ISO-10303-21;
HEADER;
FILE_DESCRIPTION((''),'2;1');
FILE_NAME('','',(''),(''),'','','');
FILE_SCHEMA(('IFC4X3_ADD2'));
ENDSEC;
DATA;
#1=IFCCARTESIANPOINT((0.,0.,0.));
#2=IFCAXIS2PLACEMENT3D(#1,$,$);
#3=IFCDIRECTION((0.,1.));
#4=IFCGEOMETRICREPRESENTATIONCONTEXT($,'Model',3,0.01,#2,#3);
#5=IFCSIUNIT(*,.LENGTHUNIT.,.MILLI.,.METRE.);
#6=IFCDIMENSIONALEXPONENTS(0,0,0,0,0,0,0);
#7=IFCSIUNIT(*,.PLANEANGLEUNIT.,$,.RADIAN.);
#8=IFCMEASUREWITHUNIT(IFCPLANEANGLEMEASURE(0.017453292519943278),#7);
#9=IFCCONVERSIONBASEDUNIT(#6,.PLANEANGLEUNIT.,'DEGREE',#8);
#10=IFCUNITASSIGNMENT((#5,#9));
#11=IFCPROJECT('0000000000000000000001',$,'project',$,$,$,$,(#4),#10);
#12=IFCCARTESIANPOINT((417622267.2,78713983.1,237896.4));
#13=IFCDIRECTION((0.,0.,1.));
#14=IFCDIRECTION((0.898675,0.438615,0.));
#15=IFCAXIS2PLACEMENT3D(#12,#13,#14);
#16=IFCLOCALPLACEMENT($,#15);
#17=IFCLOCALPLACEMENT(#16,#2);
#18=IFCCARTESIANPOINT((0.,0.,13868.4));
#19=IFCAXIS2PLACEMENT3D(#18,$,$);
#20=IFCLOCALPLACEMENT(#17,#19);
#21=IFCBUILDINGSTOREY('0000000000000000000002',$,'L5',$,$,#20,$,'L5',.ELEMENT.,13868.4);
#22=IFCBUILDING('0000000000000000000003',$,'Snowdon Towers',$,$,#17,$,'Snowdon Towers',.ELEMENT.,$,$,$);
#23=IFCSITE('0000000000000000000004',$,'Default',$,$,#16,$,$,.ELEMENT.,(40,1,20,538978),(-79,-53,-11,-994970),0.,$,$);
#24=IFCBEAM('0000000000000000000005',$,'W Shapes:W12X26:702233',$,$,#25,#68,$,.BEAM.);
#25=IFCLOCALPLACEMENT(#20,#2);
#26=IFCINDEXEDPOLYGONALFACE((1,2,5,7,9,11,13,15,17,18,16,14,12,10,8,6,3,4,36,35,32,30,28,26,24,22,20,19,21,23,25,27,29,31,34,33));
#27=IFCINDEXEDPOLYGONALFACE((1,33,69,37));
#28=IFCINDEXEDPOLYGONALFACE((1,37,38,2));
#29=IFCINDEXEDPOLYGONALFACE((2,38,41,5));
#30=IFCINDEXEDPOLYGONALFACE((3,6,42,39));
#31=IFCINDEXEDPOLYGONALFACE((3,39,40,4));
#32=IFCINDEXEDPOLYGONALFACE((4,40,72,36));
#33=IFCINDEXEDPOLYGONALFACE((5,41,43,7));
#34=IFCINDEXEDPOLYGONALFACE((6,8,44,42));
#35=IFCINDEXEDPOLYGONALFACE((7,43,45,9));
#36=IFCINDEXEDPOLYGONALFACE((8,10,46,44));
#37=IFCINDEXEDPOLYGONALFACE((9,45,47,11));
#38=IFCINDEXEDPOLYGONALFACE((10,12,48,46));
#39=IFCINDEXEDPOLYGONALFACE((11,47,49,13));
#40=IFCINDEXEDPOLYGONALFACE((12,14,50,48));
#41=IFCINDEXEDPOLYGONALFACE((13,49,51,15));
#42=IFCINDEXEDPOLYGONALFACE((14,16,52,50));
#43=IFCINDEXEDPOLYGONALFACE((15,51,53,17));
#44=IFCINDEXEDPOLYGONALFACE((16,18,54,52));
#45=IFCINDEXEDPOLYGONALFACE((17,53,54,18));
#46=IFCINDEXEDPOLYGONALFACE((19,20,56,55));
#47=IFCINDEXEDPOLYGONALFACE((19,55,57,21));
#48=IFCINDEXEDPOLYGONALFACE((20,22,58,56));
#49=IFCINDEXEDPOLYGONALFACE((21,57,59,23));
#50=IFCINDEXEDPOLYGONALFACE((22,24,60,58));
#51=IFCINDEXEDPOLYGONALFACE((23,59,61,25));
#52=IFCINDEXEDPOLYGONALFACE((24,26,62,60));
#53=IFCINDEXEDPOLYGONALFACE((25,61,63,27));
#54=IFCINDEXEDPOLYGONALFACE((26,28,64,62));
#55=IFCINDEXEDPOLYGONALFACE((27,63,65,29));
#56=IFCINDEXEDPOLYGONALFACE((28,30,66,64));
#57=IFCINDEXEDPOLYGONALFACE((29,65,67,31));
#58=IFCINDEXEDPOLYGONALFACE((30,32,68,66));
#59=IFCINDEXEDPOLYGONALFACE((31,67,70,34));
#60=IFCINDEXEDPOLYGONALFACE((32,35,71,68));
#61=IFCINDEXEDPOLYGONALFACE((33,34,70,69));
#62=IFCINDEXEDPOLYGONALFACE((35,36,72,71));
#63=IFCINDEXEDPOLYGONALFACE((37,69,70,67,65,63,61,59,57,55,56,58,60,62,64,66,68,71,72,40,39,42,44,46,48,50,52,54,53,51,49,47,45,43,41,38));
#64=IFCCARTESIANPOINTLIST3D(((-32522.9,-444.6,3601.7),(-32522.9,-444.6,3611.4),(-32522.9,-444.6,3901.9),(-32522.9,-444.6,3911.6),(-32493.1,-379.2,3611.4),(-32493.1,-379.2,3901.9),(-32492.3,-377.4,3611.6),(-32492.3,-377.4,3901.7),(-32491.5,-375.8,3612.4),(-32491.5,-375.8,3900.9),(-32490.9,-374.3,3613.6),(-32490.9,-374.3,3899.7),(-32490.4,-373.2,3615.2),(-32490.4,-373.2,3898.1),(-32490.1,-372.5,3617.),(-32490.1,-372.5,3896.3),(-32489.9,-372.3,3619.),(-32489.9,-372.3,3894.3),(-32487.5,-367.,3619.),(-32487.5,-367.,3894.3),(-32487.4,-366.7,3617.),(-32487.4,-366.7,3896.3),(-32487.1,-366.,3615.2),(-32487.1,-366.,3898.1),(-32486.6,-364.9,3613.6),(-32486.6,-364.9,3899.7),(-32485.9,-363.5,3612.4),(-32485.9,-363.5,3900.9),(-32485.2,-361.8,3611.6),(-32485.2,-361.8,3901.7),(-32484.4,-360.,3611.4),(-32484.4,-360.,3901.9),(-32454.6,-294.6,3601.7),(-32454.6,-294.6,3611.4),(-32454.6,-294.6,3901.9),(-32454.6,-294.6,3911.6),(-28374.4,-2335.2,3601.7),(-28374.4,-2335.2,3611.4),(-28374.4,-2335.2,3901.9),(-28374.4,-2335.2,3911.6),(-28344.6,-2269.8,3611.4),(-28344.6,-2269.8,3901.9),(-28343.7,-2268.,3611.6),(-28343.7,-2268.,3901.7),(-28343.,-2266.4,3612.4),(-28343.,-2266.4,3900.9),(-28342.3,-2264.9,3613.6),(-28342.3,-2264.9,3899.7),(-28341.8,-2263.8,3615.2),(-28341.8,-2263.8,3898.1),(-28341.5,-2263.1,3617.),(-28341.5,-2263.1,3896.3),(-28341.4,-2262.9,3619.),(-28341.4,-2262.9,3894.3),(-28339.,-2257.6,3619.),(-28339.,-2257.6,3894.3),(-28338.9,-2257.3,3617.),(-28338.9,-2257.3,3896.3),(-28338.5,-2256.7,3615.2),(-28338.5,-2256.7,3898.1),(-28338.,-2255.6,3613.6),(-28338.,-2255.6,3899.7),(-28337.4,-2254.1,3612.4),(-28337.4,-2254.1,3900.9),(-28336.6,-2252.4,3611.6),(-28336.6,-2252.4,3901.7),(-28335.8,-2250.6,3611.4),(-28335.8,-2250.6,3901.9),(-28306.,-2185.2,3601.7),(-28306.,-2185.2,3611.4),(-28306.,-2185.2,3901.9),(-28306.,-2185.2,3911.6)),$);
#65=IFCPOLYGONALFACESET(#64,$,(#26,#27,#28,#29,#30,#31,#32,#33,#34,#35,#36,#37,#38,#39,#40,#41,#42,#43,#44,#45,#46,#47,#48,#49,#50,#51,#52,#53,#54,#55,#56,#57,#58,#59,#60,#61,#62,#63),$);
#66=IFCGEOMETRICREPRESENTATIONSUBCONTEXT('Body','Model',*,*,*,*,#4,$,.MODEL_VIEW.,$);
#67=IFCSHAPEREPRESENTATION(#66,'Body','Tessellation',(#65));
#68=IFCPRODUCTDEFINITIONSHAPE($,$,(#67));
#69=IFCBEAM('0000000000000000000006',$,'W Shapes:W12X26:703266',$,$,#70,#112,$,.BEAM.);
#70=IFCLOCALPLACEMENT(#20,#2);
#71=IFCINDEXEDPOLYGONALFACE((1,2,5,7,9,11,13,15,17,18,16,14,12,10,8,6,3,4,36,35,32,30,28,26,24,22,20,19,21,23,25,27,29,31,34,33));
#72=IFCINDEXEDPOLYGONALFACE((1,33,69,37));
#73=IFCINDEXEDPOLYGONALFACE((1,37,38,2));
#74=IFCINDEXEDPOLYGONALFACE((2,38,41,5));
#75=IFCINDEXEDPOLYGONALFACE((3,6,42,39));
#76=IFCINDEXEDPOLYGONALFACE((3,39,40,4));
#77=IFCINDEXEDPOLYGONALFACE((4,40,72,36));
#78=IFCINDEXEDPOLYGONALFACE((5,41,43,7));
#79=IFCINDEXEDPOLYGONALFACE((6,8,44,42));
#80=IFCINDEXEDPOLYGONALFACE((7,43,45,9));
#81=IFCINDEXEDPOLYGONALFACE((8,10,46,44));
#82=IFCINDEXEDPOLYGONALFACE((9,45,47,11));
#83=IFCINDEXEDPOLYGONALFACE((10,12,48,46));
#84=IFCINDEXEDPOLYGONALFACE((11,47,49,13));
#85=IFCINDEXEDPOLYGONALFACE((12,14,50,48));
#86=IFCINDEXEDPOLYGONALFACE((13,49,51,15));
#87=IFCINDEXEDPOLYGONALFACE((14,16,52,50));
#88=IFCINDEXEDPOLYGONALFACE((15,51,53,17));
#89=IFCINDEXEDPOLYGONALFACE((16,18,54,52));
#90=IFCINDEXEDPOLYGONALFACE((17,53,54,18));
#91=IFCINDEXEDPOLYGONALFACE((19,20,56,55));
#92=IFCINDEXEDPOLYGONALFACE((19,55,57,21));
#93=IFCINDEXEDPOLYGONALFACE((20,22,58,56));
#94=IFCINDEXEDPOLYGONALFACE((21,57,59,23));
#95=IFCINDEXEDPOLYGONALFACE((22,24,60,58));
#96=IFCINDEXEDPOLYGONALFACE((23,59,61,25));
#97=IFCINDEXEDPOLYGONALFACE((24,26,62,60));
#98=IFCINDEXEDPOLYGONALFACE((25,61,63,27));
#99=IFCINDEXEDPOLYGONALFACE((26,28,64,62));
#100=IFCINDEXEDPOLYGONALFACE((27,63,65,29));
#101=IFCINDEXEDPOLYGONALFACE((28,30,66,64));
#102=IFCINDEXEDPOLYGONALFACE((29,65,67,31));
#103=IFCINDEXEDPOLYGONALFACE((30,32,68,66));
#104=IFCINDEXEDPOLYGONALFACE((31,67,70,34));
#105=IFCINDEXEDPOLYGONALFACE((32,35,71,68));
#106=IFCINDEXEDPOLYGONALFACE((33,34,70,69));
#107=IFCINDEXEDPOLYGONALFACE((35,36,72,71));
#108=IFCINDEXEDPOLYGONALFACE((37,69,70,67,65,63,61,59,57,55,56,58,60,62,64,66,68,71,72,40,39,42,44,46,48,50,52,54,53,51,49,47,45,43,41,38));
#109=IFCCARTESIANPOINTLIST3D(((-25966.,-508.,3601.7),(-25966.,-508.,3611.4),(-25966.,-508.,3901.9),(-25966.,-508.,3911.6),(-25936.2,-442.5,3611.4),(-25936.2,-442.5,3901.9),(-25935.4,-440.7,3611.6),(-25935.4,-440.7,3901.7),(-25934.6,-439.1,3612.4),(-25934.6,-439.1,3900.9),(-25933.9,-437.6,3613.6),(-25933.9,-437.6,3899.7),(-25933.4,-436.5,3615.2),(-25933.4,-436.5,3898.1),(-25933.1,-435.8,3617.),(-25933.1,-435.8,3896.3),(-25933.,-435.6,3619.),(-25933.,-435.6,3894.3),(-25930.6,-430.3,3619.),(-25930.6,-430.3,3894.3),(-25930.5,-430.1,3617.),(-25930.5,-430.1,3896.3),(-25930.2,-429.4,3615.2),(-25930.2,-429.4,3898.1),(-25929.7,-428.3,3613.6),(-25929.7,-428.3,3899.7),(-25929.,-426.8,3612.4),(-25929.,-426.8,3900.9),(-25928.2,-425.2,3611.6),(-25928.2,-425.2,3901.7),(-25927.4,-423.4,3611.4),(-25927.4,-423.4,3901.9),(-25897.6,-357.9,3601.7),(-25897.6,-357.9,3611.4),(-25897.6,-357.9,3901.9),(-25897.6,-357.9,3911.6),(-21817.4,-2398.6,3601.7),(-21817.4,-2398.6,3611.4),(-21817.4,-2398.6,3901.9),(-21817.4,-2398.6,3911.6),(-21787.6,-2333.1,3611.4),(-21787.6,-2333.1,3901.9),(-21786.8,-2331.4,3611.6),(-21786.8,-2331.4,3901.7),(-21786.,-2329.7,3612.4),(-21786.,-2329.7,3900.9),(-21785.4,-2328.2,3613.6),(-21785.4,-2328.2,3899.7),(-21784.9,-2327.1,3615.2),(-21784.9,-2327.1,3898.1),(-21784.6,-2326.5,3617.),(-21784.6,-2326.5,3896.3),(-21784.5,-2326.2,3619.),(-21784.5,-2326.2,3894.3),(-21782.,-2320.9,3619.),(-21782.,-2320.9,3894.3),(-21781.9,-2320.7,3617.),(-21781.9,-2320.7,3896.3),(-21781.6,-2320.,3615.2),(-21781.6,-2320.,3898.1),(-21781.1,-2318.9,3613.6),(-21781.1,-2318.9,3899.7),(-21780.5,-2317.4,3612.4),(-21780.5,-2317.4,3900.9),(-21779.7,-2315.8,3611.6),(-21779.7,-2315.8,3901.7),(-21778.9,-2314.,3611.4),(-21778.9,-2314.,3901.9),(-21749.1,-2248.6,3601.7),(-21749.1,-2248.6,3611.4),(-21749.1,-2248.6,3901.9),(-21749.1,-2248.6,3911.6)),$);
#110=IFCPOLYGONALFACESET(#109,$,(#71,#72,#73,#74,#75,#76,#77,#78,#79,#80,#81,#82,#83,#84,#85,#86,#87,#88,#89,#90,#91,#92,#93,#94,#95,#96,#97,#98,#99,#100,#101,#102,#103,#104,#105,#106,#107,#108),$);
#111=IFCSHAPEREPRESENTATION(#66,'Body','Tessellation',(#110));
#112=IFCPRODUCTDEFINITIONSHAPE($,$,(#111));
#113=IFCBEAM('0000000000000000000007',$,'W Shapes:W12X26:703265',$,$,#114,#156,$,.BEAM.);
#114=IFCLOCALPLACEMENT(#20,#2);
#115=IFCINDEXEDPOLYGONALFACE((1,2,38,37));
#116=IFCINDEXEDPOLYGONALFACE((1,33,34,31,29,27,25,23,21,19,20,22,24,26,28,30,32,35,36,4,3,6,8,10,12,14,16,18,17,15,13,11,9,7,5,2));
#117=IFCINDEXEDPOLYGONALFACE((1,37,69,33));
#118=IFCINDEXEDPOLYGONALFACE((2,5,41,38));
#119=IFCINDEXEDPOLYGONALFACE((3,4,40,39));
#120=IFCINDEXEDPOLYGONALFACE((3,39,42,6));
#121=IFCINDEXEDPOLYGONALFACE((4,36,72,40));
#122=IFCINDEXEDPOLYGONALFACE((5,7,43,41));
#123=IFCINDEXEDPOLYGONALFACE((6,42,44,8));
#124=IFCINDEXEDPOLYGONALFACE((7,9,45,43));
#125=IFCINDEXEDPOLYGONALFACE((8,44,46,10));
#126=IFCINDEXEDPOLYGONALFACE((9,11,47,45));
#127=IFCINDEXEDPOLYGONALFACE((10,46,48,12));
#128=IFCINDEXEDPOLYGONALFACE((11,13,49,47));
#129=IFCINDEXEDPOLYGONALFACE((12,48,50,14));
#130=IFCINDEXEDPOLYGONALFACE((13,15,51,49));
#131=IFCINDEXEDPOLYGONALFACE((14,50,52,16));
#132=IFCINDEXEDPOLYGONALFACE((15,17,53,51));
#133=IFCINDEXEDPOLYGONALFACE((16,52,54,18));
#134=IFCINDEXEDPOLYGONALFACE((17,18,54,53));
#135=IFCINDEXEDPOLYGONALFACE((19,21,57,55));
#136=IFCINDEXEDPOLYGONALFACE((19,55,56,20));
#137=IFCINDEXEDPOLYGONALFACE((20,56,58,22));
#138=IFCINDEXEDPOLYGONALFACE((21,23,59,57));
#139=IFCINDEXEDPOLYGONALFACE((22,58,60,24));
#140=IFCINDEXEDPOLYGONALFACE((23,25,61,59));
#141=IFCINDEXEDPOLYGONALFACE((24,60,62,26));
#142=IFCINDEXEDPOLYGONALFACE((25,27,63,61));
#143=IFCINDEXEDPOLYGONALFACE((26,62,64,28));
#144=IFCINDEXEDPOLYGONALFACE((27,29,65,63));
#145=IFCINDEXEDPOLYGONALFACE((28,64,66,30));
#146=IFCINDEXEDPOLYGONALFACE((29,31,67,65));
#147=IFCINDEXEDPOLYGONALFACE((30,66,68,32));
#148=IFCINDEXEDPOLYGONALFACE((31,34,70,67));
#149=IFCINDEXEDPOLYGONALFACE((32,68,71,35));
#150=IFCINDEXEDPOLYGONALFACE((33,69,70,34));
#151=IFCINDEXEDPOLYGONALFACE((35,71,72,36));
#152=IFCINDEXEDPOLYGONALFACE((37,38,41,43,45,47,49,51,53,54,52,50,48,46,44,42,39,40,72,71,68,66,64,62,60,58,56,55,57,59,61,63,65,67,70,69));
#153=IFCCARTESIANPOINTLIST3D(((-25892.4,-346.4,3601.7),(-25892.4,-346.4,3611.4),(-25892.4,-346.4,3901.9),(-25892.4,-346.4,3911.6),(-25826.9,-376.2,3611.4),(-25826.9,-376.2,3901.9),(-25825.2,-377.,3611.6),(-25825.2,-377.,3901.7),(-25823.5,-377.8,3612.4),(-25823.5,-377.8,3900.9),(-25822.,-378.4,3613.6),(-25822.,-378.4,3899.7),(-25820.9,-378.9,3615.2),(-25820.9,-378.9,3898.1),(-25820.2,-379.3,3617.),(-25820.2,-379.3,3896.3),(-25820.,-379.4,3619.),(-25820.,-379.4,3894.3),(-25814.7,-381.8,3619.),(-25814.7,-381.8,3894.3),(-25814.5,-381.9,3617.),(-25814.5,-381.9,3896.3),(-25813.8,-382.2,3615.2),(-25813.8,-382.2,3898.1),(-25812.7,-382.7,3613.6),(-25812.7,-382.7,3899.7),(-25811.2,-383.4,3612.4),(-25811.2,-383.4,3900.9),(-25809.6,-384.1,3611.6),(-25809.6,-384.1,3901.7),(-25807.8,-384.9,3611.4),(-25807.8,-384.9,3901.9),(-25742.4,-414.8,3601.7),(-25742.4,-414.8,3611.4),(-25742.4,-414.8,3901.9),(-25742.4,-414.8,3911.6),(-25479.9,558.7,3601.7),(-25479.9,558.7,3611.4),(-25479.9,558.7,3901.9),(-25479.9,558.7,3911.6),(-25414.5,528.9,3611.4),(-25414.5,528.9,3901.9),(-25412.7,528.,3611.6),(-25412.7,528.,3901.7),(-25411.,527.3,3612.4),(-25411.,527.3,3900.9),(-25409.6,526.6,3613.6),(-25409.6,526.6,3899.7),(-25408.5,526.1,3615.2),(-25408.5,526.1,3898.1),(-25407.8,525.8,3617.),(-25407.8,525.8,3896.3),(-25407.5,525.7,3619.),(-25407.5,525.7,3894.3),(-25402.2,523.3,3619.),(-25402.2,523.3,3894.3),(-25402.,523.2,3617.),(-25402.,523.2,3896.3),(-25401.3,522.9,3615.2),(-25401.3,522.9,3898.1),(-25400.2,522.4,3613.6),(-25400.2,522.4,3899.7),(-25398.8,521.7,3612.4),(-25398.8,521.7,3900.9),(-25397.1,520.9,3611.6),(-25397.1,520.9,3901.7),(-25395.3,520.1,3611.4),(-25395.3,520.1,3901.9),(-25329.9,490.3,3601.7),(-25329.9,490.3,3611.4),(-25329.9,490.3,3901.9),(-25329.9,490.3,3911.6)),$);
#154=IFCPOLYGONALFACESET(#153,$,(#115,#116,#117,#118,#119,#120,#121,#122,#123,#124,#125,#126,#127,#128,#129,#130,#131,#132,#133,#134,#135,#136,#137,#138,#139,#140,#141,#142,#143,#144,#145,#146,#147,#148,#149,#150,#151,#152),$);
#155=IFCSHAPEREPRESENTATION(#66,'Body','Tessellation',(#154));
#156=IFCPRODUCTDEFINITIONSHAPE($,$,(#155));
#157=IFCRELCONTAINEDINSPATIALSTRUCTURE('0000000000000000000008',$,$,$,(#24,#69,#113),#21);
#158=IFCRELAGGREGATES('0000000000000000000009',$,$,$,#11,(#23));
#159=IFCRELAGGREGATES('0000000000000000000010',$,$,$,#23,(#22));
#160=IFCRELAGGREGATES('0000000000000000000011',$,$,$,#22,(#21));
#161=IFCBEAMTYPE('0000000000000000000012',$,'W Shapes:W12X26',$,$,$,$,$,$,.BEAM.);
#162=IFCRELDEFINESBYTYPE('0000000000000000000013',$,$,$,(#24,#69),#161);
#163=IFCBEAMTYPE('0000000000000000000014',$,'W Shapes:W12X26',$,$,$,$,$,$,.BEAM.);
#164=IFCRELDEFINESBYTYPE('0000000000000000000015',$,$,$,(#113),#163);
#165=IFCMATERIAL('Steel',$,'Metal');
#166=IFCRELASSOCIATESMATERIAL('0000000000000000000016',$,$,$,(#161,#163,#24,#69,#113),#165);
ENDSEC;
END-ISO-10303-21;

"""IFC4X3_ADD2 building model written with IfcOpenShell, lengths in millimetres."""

from ifc_helpers import new_model, entity, si_unit, converted_unit, direction, frame, frame_2d, origin, place, context, subcontext, project, spatial, polyline, circle_curve, parameter, trimmed, segment, composite_curve, outline, extrude, source, transform, mapped, material, material_profile, profile_set, profile_usage, type_object, type_shapes, element, save


model = new_model("IFC4X3_ADD2")

# Units and contexts
model_context = context("Model", 3, precision=0.01, world=origin(), true_north=direction((0.0, 1.0)))
body_context = subcontext(model_context, "Body", "Model", "MODEL_VIEW")
ifc_project = project(units=[si_unit("LENGTHUNIT", "METRE", prefix="MILLI"), converted_unit("PLANEANGLEUNIT", "DEGREE", entity("IfcPlaneAngleMeasure", 0.017453292519943278), si_unit("PLANEANGLEUNIT", "RADIAN"), dimensions=[0, 0, 0, 0, 0, 0, 0])], contexts=[model_context])

# Site, building, storey
site_placement = place(None, frame((417622267.2, 78713983.1, 237896.4), z_axis=(0.0, 0.0, 1.0), x_axis=(0.898675, 0.438615, 0.0)))
site = spatial("IfcSite", under=ifc_project, at=site_placement, Name="Default", CompositionType="ELEMENT", RefLatitude=(40, 1, 20, 538978), RefLongitude=(-79, -53, -11, -994970), RefElevation=0.0)
building_placement = place(site_placement, origin())
building = spatial("IfcBuilding", under=site, at=building_placement, Name="Snowdon Towers", LongName="Snowdon Towers", CompositionType="ELEMENT")
storey_placement = place(building_placement, frame((0.0, 0.0, 13868.4)))
storey = spatial("IfcBuildingStorey", under=building, at=storey_placement, Name="L5", LongName="L5", CompositionType="ELEMENT", Elevation=13868.4)

# Shared definitions
ifc_material_1 = material(Name="Steel", Category="Metal")

# Beams
ifc_material_profile_1 = material_profile(ifc_material_1, outline(composite_curve([segment(polyline([(-82.4, -145.3), (-82.4, -154.9)]), True, "CONTINUOUS"), segment(polyline([(-82.4, -154.9), (82.4, -154.9)]), True, "CONTINUOUS"), segment(polyline([(82.4, -154.9), (82.4, -145.3)]), True, "CONTINUOUS"), segment(polyline([(82.4, -145.3), (10.5, -145.3)]), True, "CONTINUOUS"), segment(trimmed(circle_curve(frame_2d((10.5, -137.7), x_axis=(1.0, 0.0)), 7.6), [parameter(180.0)], [parameter(270.0)], True, "PARAMETER"), False, "CONTINUOUS"), segment(polyline([(2.9, -137.7), (2.9, 137.7)]), True, "CONTINUOUS"), segment(trimmed(circle_curve(frame_2d((10.5, 137.7), x_axis=(1.0, 0.0)), 7.6), [parameter(90.0)], [parameter(180.0)], True, "PARAMETER"), False, "CONTINUOUS"), segment(polyline([(10.5, 145.3), (82.4, 145.3)]), True, "CONTINUOUS"), segment(polyline([(82.4, 145.3), (82.4, 154.9)]), True, "CONTINUOUS"), segment(polyline([(82.4, 154.9), (-82.4, 154.9)]), True, "CONTINUOUS"), segment(polyline([(-82.4, 154.9), (-82.4, 145.3)]), True, "CONTINUOUS"), segment(polyline([(-82.4, 145.3), (-10.5, 145.3)]), True, "CONTINUOUS"), segment(trimmed(circle_curve(frame_2d((-10.5, 137.7), x_axis=(1.0, 0.0)), 7.6), [parameter(360.0)], [parameter(90.0)], True, "PARAMETER"), False, "CONTINUOUS"), segment(polyline([(-2.9, 137.7), (-2.9, -137.7)]), True, "CONTINUOUS"), segment(trimmed(circle_curve(frame_2d((-10.5, -137.7), x_axis=(1.0, 0.0)), 7.6), [parameter(270.0)], [parameter(360.0)], True, "PARAMETER"), False, "CONTINUOUS"), segment(polyline([(-10.5, -145.3), (-82.4, -145.3)]), True, "CONTINUOUS")], self_intersect=False)), Name="W12X26")
ifc_profile_set_1 = profile_set([ifc_material_profile_1], Name="W12X26")
ifc_profile_usage_1 = profile_usage(ifc_profile_set_1, cardinal=8)
beam_type_1 = type_object("IfcBeamType", Name="W Shapes:W12X26", PredefinedType="BEAM", material=ifc_profile_set_1)
shared_shape_1 = source(origin(), body_context, "Body", "SweptSolid", [
    extrude(outline(composite_curve([segment(polyline([(-82.4, -145.3), (-82.4, -154.9)]), True, "CONTINUOUS"), segment(polyline([(-82.4, -154.9), (82.4, -154.9)]), True, "CONTINUOUS"), segment(polyline([(82.4, -154.9), (82.4, -145.3)]), True, "CONTINUOUS"), segment(polyline([(82.4, -145.3), (10.5, -145.3)]), True, "CONTINUOUS"), segment(trimmed(circle_curve(frame_2d((10.5, -137.7), x_axis=(1.0, 0.0)), 7.6), [parameter(180.0)], [parameter(270.0)], True, "PARAMETER"), False, "CONTINUOUS"), segment(polyline([(2.9, -137.7), (2.9, 137.7)]), True, "CONTINUOUS"), segment(trimmed(circle_curve(frame_2d((10.5, 137.7), x_axis=(1.0, 0.0)), 7.6), [parameter(90.0)], [parameter(180.0)], True, "PARAMETER"), False, "CONTINUOUS"), segment(polyline([(10.5, 145.3), (82.4, 145.3)]), True, "CONTINUOUS"), segment(polyline([(82.4, 145.3), (82.4, 154.9)]), True, "CONTINUOUS"), segment(polyline([(82.4, 154.9), (-82.4, 154.9)]), True, "CONTINUOUS"), segment(polyline([(-82.4, 154.9), (-82.4, 145.3)]), True, "CONTINUOUS"), segment(polyline([(-82.4, 145.3), (-10.5, 145.3)]), True, "CONTINUOUS"), segment(trimmed(circle_curve(frame_2d((-10.5, 137.7), x_axis=(1.0, 0.0)), 7.6), [parameter(360.0)], [parameter(90.0)], True, "PARAMETER"), False, "CONTINUOUS"), segment(polyline([(-2.9, 137.7), (-2.9, -137.7)]), True, "CONTINUOUS"), segment(trimmed(circle_curve(frame_2d((-10.5, -137.7), x_axis=(1.0, 0.0)), 7.6), [parameter(270.0)], [parameter(360.0)], True, "PARAMETER"), False, "CONTINUOUS"), segment(polyline([(-10.5, -145.3), (-82.4, -145.3)]), True, "CONTINUOUS")], self_intersect=False)), frame((-2279.5, 0.0, 0.0), z_axis=(-1.0, 0.0, 0.0), x_axis=(0.0, -1.0, 0.0)), (0.0, 0.0, -1.0), 4559.0),
])
type_shapes(beam_type_1, [shared_shape_1])
for number, where, z_axis, x_axis, name in (
    (1, (-30414.5, -1314.9, 3756.7), (0.0, 0.0, 1.0), (0.909961, -0.414693, 0.0), "W Shapes:W12X26:702233"),
    (2, (-23857.5, -1378.3, 3756.7), (0.0, 0.0, 1.0), (0.909961, -0.414693, 0.0), "W Shapes:W12X26:703266"),
):
    element("IfcBeam", number, at=place(storey_placement, frame(where, z_axis=z_axis, x_axis=x_axis)), inside=storey, type_object=beam_type_1, material=ifc_profile_usage_1, Name=name, PredefinedType="BEAM", context=body_context, shape_type="MappedRepresentation", body=[
        mapped(shared_shape_1, transform((0.0, 0.0, 0.0), scale=1.0)),
    ])
beam_type_2 = type_object("IfcBeamType", Name="W Shapes:W12X26", PredefinedType="BEAM", material=ifc_profile_set_1)
shared_shape_2 = source(origin(), body_context, "Body", "SweptSolid", [
    extrude(outline(composite_curve([segment(polyline([(-82.4, -145.3), (-82.4, -154.9)]), True, "CONTINUOUS"), segment(polyline([(-82.4, -154.9), (82.4, -154.9)]), True, "CONTINUOUS"), segment(polyline([(82.4, -154.9), (82.4, -145.3)]), True, "CONTINUOUS"), segment(polyline([(82.4, -145.3), (10.5, -145.3)]), True, "CONTINUOUS"), segment(trimmed(circle_curve(frame_2d((10.5, -137.7), x_axis=(0.0, -1.0)), 7.6), [parameter(270.0)], [parameter(360.0)], True, "PARAMETER"), False, "CONTINUOUS"), segment(polyline([(2.9, -137.7), (2.9, 137.7)]), True, "CONTINUOUS"), segment(trimmed(circle_curve(frame_2d((10.5, 137.7), x_axis=(-1.0, 0.0)), 7.6), [parameter(270.0)], [parameter(360.0)], True, "PARAMETER"), False, "CONTINUOUS"), segment(polyline([(10.5, 145.3), (82.4, 145.3)]), True, "CONTINUOUS"), segment(polyline([(82.4, 145.3), (82.4, 154.9)]), True, "CONTINUOUS"), segment(polyline([(82.4, 154.9), (-82.4, 154.9)]), True, "CONTINUOUS"), segment(polyline([(-82.4, 154.9), (-82.4, 145.3)]), True, "CONTINUOUS"), segment(polyline([(-82.4, 145.3), (-10.5, 145.3)]), True, "CONTINUOUS"), segment(trimmed(circle_curve(frame_2d((-10.5, 137.7), x_axis=(0.0, 1.0)), 7.6), [parameter(270.0)], [parameter(0.0)], True, "PARAMETER"), False, "CONTINUOUS"), segment(polyline([(-2.9, 137.7), (-2.9, -137.7)]), True, "CONTINUOUS"), segment(trimmed(circle_curve(frame_2d((-10.5, -137.7), x_axis=(1.0, 0.0)), 7.6), [parameter(270.0)], [parameter(0.0)], True, "PARAMETER"), False, "CONTINUOUS"), segment(polyline([(-10.5, -145.3), (-82.4, -145.3)]), True, "CONTINUOUS")], self_intersect=False)), frame((-580.3, 0.0, 0.0), z_axis=(-1.0, 0.0, 0.0), x_axis=(0.0, -1.0, 0.0)), (0.0, 0.0, -1.0), 994.6),
])
type_shapes(beam_type_2, [shared_shape_2])
beam_1_placement = place(storey_placement, frame((-25576.7, 147.4, 3756.7), z_axis=(0.0, 0.0, 1.0), x_axis=(0.414693, 0.909961, 0.0)))
element("IfcBeam", 3, at=beam_1_placement, inside=storey, type_object=beam_type_2, material=ifc_profile_usage_1, Name="W Shapes:W12X26:703265", PredefinedType="BEAM", context=body_context, shape_type="MappedRepresentation", body=[
    mapped(shared_shape_2, transform((0.0, 0.0, 0.0), scale=1.0)),
])

save(model, "model.ifc")
